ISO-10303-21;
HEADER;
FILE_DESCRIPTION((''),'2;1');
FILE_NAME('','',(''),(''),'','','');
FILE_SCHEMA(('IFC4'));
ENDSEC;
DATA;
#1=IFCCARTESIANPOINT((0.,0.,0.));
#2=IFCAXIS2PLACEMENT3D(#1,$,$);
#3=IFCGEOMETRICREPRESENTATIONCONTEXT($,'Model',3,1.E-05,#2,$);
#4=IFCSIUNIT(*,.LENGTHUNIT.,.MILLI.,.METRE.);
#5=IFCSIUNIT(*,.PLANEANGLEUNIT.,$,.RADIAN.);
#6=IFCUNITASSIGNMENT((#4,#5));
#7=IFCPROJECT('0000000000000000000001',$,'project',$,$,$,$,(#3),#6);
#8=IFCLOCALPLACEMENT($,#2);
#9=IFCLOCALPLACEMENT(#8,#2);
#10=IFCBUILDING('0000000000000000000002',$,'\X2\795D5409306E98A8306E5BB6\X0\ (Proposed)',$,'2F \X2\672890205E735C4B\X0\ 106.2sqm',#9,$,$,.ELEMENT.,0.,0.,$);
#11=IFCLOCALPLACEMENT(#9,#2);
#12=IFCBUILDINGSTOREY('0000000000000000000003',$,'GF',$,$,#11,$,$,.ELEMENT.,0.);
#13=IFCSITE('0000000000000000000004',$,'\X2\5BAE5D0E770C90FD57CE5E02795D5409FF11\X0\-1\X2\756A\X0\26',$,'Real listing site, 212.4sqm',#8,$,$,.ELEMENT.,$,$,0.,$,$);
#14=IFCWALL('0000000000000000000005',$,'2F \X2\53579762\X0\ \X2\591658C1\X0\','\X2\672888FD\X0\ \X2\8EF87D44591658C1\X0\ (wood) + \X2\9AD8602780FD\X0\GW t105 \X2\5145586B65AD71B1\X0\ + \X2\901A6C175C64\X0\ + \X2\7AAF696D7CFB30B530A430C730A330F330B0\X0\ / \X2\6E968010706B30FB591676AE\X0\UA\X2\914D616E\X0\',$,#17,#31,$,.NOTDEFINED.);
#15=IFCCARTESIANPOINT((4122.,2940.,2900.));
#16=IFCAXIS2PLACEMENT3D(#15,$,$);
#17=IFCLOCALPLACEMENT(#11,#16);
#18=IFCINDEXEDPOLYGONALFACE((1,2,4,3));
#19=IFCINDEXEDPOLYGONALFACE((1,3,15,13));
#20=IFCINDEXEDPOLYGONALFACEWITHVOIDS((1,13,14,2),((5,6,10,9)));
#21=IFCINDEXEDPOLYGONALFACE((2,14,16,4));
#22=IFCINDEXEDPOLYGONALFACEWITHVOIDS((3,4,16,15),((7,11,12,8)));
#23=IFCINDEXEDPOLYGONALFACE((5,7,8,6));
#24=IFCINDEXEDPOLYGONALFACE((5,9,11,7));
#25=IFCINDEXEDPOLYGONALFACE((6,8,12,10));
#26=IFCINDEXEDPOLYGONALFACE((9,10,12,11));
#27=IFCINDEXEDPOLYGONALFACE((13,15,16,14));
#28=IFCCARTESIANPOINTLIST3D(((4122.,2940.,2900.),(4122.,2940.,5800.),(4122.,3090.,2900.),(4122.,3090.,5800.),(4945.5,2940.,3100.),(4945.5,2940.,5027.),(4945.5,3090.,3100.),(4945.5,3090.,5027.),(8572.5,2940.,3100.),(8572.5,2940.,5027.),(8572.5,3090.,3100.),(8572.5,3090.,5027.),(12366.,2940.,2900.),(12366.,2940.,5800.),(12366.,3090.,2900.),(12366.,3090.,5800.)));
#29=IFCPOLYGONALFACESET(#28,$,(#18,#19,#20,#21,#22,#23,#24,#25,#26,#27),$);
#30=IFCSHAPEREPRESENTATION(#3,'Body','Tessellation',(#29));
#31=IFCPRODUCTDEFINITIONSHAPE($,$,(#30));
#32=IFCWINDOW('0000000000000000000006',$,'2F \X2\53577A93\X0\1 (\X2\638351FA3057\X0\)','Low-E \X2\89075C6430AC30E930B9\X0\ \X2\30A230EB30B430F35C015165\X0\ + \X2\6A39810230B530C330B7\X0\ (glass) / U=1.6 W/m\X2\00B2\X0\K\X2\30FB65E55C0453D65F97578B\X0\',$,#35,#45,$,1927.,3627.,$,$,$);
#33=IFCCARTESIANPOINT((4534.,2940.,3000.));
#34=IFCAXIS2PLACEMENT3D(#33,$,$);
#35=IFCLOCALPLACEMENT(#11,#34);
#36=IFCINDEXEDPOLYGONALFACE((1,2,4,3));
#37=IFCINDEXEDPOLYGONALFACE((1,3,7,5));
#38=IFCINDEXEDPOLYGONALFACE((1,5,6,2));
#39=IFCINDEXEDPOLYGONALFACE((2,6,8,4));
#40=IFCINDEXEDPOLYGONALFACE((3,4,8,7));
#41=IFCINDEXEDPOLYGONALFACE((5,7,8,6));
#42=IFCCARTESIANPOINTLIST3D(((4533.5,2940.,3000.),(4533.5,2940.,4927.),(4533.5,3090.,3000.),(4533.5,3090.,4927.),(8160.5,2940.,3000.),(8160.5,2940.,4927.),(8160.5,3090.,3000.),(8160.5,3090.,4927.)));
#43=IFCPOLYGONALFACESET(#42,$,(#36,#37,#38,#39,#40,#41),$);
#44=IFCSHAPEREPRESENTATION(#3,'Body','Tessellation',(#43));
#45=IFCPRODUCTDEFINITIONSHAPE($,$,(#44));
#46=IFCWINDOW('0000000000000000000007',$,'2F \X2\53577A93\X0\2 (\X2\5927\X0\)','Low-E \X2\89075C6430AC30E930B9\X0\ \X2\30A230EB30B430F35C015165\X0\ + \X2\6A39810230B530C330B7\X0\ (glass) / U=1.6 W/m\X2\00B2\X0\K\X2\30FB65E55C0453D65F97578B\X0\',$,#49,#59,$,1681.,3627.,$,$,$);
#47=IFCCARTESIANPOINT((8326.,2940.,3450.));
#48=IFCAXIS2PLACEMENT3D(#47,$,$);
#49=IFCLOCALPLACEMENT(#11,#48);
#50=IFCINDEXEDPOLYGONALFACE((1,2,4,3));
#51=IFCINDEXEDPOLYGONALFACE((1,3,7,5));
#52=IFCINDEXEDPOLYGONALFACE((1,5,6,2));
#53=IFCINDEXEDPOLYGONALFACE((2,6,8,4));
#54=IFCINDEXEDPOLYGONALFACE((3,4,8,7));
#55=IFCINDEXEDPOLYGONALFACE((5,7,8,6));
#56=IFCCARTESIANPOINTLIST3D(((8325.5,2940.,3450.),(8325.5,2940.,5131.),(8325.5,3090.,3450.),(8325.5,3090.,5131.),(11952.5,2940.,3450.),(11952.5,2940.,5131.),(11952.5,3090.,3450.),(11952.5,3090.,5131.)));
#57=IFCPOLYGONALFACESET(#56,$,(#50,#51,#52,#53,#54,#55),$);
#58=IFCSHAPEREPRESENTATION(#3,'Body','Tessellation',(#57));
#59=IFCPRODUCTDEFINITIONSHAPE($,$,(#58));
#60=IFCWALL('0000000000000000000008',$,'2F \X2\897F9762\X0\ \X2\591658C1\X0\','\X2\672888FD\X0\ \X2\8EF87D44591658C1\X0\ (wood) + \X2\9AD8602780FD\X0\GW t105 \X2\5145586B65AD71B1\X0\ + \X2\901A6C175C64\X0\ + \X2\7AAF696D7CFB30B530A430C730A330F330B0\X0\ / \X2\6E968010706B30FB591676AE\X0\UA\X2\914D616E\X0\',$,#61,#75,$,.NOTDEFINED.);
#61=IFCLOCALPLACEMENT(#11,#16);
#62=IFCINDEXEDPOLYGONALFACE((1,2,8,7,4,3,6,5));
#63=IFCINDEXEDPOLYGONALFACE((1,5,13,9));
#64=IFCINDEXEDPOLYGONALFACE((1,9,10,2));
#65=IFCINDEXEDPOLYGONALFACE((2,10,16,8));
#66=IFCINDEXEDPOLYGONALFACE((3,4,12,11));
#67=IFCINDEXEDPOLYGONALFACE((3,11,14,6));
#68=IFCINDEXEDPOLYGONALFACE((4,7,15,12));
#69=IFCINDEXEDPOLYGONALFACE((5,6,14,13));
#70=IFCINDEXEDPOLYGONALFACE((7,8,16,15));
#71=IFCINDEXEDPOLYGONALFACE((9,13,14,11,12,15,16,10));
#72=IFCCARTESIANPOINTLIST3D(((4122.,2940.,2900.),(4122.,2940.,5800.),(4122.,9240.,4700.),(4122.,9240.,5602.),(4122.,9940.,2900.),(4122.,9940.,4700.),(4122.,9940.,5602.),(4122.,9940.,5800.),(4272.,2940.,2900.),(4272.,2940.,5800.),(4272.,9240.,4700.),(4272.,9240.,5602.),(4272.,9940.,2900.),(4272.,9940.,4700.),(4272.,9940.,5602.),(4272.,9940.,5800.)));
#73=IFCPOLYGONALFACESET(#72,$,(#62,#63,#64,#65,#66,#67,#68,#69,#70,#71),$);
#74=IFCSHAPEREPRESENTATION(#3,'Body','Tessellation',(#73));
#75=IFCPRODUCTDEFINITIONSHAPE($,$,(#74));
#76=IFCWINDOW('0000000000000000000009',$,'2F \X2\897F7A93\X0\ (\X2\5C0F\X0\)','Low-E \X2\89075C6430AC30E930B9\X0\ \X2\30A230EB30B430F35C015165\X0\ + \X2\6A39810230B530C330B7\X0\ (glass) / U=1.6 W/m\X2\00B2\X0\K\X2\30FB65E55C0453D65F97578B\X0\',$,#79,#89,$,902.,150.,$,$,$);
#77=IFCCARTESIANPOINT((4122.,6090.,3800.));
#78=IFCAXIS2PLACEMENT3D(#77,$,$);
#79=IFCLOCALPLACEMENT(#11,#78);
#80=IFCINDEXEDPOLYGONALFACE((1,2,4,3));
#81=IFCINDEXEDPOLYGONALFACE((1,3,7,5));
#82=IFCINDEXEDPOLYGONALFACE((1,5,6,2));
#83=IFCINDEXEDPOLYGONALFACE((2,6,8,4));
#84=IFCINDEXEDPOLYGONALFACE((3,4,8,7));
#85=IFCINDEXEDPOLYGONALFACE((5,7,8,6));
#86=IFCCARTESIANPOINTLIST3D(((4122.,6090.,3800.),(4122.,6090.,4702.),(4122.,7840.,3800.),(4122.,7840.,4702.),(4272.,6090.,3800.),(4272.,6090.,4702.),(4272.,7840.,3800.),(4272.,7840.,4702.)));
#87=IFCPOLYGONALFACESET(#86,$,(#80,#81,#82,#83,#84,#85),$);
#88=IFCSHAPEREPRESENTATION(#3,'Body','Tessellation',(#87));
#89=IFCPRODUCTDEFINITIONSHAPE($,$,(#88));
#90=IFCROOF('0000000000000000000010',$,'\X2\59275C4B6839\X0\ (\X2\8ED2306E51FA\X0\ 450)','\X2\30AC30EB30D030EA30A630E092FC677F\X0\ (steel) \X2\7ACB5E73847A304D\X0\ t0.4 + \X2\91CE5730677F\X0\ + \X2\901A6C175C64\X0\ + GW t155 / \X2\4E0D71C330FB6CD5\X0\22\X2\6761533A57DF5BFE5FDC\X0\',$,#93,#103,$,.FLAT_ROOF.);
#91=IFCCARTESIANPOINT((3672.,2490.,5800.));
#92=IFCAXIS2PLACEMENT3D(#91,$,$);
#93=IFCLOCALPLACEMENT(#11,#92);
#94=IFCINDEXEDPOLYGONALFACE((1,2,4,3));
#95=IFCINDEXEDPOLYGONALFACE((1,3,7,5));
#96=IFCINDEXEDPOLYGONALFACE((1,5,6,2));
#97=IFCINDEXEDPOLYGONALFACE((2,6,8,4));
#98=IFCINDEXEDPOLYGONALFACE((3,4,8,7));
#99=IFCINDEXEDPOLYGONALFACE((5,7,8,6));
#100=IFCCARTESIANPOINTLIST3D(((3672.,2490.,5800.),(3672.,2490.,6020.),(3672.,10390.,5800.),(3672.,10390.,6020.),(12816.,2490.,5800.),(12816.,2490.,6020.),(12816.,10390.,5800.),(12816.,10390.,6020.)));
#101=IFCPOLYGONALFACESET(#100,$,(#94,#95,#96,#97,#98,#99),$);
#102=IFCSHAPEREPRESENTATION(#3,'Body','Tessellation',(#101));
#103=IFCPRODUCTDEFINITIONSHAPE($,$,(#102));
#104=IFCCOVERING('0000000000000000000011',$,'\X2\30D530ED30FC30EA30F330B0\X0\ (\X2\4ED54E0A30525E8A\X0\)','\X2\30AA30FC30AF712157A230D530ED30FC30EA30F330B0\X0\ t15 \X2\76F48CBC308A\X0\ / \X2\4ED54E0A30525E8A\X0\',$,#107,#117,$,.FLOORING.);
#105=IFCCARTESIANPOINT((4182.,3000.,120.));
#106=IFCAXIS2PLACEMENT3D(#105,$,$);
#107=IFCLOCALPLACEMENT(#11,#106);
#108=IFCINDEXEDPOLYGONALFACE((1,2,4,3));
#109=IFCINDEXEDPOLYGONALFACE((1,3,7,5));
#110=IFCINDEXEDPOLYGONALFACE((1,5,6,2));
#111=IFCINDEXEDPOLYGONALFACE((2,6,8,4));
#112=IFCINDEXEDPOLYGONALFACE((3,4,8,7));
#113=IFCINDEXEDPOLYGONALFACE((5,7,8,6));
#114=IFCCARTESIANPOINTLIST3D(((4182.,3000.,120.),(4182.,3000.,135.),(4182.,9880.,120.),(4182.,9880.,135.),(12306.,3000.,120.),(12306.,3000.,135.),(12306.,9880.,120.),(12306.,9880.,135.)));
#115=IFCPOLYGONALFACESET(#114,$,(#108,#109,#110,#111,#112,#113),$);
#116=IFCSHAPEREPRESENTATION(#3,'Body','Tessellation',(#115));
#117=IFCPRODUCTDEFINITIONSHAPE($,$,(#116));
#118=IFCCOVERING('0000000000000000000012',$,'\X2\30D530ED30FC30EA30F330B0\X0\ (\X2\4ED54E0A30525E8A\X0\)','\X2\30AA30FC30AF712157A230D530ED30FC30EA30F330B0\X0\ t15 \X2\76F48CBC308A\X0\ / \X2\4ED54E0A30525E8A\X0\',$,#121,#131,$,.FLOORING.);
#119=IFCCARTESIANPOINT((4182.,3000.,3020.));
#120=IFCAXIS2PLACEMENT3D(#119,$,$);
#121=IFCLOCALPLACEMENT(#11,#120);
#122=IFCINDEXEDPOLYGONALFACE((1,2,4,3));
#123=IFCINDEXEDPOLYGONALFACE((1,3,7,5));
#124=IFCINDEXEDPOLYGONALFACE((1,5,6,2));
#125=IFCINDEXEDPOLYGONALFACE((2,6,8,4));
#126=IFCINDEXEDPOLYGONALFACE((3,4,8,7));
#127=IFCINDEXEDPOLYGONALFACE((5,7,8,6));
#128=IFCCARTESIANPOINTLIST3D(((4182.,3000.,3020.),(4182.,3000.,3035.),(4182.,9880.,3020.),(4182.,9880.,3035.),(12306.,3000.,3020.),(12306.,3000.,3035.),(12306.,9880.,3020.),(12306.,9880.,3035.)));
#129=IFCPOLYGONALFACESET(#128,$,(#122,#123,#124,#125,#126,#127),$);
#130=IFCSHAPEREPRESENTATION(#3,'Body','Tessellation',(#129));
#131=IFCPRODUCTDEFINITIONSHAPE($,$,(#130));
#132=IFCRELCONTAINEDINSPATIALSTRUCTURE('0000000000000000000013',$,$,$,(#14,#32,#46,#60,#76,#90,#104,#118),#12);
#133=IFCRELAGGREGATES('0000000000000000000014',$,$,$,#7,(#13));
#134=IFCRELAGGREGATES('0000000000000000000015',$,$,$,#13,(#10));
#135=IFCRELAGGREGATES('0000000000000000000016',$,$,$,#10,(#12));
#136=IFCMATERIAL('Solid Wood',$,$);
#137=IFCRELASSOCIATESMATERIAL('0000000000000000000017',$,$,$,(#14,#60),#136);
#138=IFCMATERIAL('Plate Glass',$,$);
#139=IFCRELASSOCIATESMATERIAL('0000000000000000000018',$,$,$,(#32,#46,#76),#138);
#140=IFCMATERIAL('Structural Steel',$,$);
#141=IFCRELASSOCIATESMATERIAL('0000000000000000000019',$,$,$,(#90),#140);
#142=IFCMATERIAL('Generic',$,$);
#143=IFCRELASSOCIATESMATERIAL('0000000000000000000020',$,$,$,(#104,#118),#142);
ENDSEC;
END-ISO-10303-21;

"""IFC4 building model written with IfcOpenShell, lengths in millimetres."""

from ifc_helpers import new_model, si_unit, frame, frame_2d, origin, place, context, project, spatial, rectangle, extrude, material, element, fill, save


model = new_model("IFC4")

# Units and contexts
model_context = context("Model", 3, precision=1e-05, world=origin())
ifc_project = project(units=[si_unit("LENGTHUNIT", "METRE", prefix="MILLI"), si_unit("PLANEANGLEUNIT", "RADIAN")], contexts=[model_context])

# Site, building, storey
site_placement = place(None, origin())
site = spatial("IfcSite", under=ifc_project, at=site_placement, Name="宮崎県都城市祝吉１-1番26", ObjectType="Real listing site, 212.4sqm", CompositionType="ELEMENT", RefElevation=0.0)
building_placement = place(site_placement, origin())
building = spatial("IfcBuilding", under=site, at=building_placement, Name="祝吉の風の家 (Proposed)", ObjectType="2F 木造平屋 106.2sqm", CompositionType="ELEMENT", ElevationOfRefHeight=0.0, ElevationOfTerrain=0.0)
storey_placement = place(building_placement, origin())
storey = spatial("IfcBuildingStorey", under=building, at=storey_placement, Name="GF", CompositionType="ELEMENT", Elevation=0.0)

# Shared definitions
ifc_material_1 = material(Name="Solid Wood")

# Shared definitions
ifc_material_2 = material(Name="Plate Glass")

# Wall, openings, windows
wall_1_placement = place(storey_placement, frame((4122.0, 2940.0, 2900.0)))
wall_1 = element("IfcWall", 1, at=wall_1_placement, inside=storey, material=ifc_material_1, Name="2F 南面 外壁", Description="木製 軸組外壁 (wood) + 高性能GW t105 充填断熱 + 通気層 + 窯業系サイディング / 準耐火・外皮UA配慮", PredefinedType="NOTDEFINED", context=model_context, shape_type="SweptSolid", body=[
    extrude(rectangle(XDim=8244.0, YDim=150.0, at=frame_2d((4122.0, 75.0))), frame((4122.0, 2940.0, 2900.0)), (0.0, 0.0, 1.0), 2900.0),
])
opening_1_placement = place(storey_placement, frame((4534.0, 2940.0, 3000.0)))
opening_1 = element("IfcOpeningElement", 2, at=opening_1_placement, cuts=wall_1, PredefinedType="NOTDEFINED", context=model_context, shape_type="SweptSolid", body=[
    extrude(rectangle(XDim=3627.0, YDim=150.0, at=frame_2d((1813.0, 75.0))), frame((4534.0, 2940.0, 3000.0)), (0.0, 0.0, 1.0), 1927.0),
])
opening_2_placement = place(storey_placement, frame((8326.0, 2940.0, 3450.0)))
opening_2 = element("IfcOpeningElement", 3, at=opening_2_placement, cuts=wall_1, PredefinedType="NOTDEFINED", context=model_context, shape_type="SweptSolid", body=[
    extrude(rectangle(XDim=3627.0, YDim=150.0, at=frame_2d((1813.0, 75.0))), frame((8326.0, 2940.0, 3450.0)), (0.0, 0.0, 1.0), 1681.0),
])
window_1_placement = place(storey_placement, frame((4534.0, 2940.0, 3000.0)))
window_1 = element("IfcWindow", 4, at=window_1_placement, inside=storey, material=ifc_material_2, Name="2F 南窓1 (掃出し)", Description="Low-E 複層ガラス アルゴン封入 + 樹脂サッシ (glass) / U=1.6 W/m²K・日射取得型", OverallHeight=1927.0, OverallWidth=3627.0, context=model_context, shape_type="SweptSolid", body=[
    extrude(rectangle(XDim=3627.0, YDim=150.0, at=frame_2d((1813.0, 75.0))), frame((4534.0, 2940.0, 3000.0)), (0.0, 0.0, 1.0), 1927.0),
])
fill(opening_1, window_1)
window_2_placement = place(storey_placement, frame((8326.0, 2940.0, 3450.0)))
window_2 = element("IfcWindow", 5, at=window_2_placement, inside=storey, material=ifc_material_2, Name="2F 南窓2 (大)", Description="Low-E 複層ガラス アルゴン封入 + 樹脂サッシ (glass) / U=1.6 W/m²K・日射取得型", OverallHeight=1681.0, OverallWidth=3627.0, context=model_context, shape_type="SweptSolid", body=[
    extrude(rectangle(XDim=3627.0, YDim=150.0, at=frame_2d((1813.0, 75.0))), frame((8326.0, 2940.0, 3450.0)), (0.0, 0.0, 1.0), 1681.0),
])
fill(opening_2, window_2)

# Wall, opening, window
wall_2_placement = place(storey_placement, frame((4122.0, 2940.0, 2900.0)))
wall_2 = element("IfcWall", 6, at=wall_2_placement, inside=storey, material=ifc_material_1, Name="2F 西面 外壁", Description="木製 軸組外壁 (wood) + 高性能GW t105 充填断熱 + 通気層 + 窯業系サイディング / 準耐火・外皮UA配慮", PredefinedType="NOTDEFINED", context=model_context, shape_type="SweptSolid", body=[
    extrude(rectangle(XDim=150.0, YDim=7000.0, at=frame_2d((75.0, 3500.0))), frame((4122.0, 2940.0, 2900.0)), (0.0, 0.0, 1.0), 2900.0),
])
opening_3_placement = place(storey_placement, frame((4122.0, 6090.0, 3800.0)))
opening_3 = element("IfcOpeningElement", 7, at=opening_3_placement, cuts=wall_2, PredefinedType="NOTDEFINED", context=model_context, shape_type="SweptSolid", body=[
    extrude(rectangle(XDim=150.0, YDim=1750.0, at=frame_2d((75.0, 875.0))), frame((4122.0, 6090.0, 3800.0)), (0.0, 0.0, 1.0), 902.0),
])
window_3_placement = place(storey_placement, frame((4122.0, 6090.0, 3800.0)))
window_3 = element("IfcWindow", 8, at=window_3_placement, inside=storey, material=ifc_material_2, Name="2F 西窓 (小)", Description="Low-E 複層ガラス アルゴン封入 + 樹脂サッシ (glass) / U=1.6 W/m²K・日射取得型", OverallHeight=902.0, OverallWidth=150.0, context=model_context, shape_type="SweptSolid", body=[
    extrude(rectangle(XDim=150.0, YDim=1750.0, at=frame_2d((75.0, 875.0))), frame((4122.0, 6090.0, 3800.0)), (0.0, 0.0, 1.0), 902.0),
])
fill(opening_3, window_3)

# Roof
ifc_material_3 = material(Name="Structural Steel")
roof_placement = place(storey_placement, frame((3672.0, 2490.0, 5800.0)))
element("IfcRoof", 9, at=roof_placement, inside=storey, material=ifc_material_3, Name="大屋根 (軒の出 450)", Description="ガルバリウム鋼板 (steel) 立平葺き t0.4 + 野地板 + 通気層 + GW t155 / 不燃・法22条区域対応", PredefinedType="FLAT_ROOF", context=model_context, shape_type="SweptSolid", body=[
    extrude(rectangle(XDim=9144.0, YDim=7900.0, at=frame_2d((4572.0, 3950.0))), frame((3672.0, 2490.0, 5800.0)), (0.0, 0.0, 1.0), 220.0),
])

# Coverings
ifc_material_4 = material(Name="Generic")
covering_1_placement = place(storey_placement, frame((4182.0, 3000.0, 120.0)))
element("IfcCovering", 10, at=covering_1_placement, inside=storey, material=ifc_material_4, Name="フローリング (仕上げ床)", Description="オーク無垢フローリング t15 直貼り / 仕上げ床", PredefinedType="FLOORING", context=model_context, shape_type="SweptSolid", body=[
    extrude(rectangle(XDim=8124.0, YDim=6880.0, at=frame_2d((4062.0, 3440.0))), frame((4182.0, 3000.0, 120.0)), (0.0, 0.0, 1.0), 15.0),
])
covering_2_placement = place(storey_placement, frame((4182.0, 3000.0, 3020.0)))
element("IfcCovering", 11, at=covering_2_placement, inside=storey, material=ifc_material_4, Name="フローリング (仕上げ床)", Description="オーク無垢フローリング t15 直貼り / 仕上げ床", PredefinedType="FLOORING", context=model_context, shape_type="SweptSolid", body=[
    extrude(rectangle(XDim=8124.0, YDim=6880.0, at=frame_2d((4062.0, 3440.0))), frame((4182.0, 3000.0, 3020.0)), (0.0, 0.0, 1.0), 15.0),
])

save(model, "model.ifc")
